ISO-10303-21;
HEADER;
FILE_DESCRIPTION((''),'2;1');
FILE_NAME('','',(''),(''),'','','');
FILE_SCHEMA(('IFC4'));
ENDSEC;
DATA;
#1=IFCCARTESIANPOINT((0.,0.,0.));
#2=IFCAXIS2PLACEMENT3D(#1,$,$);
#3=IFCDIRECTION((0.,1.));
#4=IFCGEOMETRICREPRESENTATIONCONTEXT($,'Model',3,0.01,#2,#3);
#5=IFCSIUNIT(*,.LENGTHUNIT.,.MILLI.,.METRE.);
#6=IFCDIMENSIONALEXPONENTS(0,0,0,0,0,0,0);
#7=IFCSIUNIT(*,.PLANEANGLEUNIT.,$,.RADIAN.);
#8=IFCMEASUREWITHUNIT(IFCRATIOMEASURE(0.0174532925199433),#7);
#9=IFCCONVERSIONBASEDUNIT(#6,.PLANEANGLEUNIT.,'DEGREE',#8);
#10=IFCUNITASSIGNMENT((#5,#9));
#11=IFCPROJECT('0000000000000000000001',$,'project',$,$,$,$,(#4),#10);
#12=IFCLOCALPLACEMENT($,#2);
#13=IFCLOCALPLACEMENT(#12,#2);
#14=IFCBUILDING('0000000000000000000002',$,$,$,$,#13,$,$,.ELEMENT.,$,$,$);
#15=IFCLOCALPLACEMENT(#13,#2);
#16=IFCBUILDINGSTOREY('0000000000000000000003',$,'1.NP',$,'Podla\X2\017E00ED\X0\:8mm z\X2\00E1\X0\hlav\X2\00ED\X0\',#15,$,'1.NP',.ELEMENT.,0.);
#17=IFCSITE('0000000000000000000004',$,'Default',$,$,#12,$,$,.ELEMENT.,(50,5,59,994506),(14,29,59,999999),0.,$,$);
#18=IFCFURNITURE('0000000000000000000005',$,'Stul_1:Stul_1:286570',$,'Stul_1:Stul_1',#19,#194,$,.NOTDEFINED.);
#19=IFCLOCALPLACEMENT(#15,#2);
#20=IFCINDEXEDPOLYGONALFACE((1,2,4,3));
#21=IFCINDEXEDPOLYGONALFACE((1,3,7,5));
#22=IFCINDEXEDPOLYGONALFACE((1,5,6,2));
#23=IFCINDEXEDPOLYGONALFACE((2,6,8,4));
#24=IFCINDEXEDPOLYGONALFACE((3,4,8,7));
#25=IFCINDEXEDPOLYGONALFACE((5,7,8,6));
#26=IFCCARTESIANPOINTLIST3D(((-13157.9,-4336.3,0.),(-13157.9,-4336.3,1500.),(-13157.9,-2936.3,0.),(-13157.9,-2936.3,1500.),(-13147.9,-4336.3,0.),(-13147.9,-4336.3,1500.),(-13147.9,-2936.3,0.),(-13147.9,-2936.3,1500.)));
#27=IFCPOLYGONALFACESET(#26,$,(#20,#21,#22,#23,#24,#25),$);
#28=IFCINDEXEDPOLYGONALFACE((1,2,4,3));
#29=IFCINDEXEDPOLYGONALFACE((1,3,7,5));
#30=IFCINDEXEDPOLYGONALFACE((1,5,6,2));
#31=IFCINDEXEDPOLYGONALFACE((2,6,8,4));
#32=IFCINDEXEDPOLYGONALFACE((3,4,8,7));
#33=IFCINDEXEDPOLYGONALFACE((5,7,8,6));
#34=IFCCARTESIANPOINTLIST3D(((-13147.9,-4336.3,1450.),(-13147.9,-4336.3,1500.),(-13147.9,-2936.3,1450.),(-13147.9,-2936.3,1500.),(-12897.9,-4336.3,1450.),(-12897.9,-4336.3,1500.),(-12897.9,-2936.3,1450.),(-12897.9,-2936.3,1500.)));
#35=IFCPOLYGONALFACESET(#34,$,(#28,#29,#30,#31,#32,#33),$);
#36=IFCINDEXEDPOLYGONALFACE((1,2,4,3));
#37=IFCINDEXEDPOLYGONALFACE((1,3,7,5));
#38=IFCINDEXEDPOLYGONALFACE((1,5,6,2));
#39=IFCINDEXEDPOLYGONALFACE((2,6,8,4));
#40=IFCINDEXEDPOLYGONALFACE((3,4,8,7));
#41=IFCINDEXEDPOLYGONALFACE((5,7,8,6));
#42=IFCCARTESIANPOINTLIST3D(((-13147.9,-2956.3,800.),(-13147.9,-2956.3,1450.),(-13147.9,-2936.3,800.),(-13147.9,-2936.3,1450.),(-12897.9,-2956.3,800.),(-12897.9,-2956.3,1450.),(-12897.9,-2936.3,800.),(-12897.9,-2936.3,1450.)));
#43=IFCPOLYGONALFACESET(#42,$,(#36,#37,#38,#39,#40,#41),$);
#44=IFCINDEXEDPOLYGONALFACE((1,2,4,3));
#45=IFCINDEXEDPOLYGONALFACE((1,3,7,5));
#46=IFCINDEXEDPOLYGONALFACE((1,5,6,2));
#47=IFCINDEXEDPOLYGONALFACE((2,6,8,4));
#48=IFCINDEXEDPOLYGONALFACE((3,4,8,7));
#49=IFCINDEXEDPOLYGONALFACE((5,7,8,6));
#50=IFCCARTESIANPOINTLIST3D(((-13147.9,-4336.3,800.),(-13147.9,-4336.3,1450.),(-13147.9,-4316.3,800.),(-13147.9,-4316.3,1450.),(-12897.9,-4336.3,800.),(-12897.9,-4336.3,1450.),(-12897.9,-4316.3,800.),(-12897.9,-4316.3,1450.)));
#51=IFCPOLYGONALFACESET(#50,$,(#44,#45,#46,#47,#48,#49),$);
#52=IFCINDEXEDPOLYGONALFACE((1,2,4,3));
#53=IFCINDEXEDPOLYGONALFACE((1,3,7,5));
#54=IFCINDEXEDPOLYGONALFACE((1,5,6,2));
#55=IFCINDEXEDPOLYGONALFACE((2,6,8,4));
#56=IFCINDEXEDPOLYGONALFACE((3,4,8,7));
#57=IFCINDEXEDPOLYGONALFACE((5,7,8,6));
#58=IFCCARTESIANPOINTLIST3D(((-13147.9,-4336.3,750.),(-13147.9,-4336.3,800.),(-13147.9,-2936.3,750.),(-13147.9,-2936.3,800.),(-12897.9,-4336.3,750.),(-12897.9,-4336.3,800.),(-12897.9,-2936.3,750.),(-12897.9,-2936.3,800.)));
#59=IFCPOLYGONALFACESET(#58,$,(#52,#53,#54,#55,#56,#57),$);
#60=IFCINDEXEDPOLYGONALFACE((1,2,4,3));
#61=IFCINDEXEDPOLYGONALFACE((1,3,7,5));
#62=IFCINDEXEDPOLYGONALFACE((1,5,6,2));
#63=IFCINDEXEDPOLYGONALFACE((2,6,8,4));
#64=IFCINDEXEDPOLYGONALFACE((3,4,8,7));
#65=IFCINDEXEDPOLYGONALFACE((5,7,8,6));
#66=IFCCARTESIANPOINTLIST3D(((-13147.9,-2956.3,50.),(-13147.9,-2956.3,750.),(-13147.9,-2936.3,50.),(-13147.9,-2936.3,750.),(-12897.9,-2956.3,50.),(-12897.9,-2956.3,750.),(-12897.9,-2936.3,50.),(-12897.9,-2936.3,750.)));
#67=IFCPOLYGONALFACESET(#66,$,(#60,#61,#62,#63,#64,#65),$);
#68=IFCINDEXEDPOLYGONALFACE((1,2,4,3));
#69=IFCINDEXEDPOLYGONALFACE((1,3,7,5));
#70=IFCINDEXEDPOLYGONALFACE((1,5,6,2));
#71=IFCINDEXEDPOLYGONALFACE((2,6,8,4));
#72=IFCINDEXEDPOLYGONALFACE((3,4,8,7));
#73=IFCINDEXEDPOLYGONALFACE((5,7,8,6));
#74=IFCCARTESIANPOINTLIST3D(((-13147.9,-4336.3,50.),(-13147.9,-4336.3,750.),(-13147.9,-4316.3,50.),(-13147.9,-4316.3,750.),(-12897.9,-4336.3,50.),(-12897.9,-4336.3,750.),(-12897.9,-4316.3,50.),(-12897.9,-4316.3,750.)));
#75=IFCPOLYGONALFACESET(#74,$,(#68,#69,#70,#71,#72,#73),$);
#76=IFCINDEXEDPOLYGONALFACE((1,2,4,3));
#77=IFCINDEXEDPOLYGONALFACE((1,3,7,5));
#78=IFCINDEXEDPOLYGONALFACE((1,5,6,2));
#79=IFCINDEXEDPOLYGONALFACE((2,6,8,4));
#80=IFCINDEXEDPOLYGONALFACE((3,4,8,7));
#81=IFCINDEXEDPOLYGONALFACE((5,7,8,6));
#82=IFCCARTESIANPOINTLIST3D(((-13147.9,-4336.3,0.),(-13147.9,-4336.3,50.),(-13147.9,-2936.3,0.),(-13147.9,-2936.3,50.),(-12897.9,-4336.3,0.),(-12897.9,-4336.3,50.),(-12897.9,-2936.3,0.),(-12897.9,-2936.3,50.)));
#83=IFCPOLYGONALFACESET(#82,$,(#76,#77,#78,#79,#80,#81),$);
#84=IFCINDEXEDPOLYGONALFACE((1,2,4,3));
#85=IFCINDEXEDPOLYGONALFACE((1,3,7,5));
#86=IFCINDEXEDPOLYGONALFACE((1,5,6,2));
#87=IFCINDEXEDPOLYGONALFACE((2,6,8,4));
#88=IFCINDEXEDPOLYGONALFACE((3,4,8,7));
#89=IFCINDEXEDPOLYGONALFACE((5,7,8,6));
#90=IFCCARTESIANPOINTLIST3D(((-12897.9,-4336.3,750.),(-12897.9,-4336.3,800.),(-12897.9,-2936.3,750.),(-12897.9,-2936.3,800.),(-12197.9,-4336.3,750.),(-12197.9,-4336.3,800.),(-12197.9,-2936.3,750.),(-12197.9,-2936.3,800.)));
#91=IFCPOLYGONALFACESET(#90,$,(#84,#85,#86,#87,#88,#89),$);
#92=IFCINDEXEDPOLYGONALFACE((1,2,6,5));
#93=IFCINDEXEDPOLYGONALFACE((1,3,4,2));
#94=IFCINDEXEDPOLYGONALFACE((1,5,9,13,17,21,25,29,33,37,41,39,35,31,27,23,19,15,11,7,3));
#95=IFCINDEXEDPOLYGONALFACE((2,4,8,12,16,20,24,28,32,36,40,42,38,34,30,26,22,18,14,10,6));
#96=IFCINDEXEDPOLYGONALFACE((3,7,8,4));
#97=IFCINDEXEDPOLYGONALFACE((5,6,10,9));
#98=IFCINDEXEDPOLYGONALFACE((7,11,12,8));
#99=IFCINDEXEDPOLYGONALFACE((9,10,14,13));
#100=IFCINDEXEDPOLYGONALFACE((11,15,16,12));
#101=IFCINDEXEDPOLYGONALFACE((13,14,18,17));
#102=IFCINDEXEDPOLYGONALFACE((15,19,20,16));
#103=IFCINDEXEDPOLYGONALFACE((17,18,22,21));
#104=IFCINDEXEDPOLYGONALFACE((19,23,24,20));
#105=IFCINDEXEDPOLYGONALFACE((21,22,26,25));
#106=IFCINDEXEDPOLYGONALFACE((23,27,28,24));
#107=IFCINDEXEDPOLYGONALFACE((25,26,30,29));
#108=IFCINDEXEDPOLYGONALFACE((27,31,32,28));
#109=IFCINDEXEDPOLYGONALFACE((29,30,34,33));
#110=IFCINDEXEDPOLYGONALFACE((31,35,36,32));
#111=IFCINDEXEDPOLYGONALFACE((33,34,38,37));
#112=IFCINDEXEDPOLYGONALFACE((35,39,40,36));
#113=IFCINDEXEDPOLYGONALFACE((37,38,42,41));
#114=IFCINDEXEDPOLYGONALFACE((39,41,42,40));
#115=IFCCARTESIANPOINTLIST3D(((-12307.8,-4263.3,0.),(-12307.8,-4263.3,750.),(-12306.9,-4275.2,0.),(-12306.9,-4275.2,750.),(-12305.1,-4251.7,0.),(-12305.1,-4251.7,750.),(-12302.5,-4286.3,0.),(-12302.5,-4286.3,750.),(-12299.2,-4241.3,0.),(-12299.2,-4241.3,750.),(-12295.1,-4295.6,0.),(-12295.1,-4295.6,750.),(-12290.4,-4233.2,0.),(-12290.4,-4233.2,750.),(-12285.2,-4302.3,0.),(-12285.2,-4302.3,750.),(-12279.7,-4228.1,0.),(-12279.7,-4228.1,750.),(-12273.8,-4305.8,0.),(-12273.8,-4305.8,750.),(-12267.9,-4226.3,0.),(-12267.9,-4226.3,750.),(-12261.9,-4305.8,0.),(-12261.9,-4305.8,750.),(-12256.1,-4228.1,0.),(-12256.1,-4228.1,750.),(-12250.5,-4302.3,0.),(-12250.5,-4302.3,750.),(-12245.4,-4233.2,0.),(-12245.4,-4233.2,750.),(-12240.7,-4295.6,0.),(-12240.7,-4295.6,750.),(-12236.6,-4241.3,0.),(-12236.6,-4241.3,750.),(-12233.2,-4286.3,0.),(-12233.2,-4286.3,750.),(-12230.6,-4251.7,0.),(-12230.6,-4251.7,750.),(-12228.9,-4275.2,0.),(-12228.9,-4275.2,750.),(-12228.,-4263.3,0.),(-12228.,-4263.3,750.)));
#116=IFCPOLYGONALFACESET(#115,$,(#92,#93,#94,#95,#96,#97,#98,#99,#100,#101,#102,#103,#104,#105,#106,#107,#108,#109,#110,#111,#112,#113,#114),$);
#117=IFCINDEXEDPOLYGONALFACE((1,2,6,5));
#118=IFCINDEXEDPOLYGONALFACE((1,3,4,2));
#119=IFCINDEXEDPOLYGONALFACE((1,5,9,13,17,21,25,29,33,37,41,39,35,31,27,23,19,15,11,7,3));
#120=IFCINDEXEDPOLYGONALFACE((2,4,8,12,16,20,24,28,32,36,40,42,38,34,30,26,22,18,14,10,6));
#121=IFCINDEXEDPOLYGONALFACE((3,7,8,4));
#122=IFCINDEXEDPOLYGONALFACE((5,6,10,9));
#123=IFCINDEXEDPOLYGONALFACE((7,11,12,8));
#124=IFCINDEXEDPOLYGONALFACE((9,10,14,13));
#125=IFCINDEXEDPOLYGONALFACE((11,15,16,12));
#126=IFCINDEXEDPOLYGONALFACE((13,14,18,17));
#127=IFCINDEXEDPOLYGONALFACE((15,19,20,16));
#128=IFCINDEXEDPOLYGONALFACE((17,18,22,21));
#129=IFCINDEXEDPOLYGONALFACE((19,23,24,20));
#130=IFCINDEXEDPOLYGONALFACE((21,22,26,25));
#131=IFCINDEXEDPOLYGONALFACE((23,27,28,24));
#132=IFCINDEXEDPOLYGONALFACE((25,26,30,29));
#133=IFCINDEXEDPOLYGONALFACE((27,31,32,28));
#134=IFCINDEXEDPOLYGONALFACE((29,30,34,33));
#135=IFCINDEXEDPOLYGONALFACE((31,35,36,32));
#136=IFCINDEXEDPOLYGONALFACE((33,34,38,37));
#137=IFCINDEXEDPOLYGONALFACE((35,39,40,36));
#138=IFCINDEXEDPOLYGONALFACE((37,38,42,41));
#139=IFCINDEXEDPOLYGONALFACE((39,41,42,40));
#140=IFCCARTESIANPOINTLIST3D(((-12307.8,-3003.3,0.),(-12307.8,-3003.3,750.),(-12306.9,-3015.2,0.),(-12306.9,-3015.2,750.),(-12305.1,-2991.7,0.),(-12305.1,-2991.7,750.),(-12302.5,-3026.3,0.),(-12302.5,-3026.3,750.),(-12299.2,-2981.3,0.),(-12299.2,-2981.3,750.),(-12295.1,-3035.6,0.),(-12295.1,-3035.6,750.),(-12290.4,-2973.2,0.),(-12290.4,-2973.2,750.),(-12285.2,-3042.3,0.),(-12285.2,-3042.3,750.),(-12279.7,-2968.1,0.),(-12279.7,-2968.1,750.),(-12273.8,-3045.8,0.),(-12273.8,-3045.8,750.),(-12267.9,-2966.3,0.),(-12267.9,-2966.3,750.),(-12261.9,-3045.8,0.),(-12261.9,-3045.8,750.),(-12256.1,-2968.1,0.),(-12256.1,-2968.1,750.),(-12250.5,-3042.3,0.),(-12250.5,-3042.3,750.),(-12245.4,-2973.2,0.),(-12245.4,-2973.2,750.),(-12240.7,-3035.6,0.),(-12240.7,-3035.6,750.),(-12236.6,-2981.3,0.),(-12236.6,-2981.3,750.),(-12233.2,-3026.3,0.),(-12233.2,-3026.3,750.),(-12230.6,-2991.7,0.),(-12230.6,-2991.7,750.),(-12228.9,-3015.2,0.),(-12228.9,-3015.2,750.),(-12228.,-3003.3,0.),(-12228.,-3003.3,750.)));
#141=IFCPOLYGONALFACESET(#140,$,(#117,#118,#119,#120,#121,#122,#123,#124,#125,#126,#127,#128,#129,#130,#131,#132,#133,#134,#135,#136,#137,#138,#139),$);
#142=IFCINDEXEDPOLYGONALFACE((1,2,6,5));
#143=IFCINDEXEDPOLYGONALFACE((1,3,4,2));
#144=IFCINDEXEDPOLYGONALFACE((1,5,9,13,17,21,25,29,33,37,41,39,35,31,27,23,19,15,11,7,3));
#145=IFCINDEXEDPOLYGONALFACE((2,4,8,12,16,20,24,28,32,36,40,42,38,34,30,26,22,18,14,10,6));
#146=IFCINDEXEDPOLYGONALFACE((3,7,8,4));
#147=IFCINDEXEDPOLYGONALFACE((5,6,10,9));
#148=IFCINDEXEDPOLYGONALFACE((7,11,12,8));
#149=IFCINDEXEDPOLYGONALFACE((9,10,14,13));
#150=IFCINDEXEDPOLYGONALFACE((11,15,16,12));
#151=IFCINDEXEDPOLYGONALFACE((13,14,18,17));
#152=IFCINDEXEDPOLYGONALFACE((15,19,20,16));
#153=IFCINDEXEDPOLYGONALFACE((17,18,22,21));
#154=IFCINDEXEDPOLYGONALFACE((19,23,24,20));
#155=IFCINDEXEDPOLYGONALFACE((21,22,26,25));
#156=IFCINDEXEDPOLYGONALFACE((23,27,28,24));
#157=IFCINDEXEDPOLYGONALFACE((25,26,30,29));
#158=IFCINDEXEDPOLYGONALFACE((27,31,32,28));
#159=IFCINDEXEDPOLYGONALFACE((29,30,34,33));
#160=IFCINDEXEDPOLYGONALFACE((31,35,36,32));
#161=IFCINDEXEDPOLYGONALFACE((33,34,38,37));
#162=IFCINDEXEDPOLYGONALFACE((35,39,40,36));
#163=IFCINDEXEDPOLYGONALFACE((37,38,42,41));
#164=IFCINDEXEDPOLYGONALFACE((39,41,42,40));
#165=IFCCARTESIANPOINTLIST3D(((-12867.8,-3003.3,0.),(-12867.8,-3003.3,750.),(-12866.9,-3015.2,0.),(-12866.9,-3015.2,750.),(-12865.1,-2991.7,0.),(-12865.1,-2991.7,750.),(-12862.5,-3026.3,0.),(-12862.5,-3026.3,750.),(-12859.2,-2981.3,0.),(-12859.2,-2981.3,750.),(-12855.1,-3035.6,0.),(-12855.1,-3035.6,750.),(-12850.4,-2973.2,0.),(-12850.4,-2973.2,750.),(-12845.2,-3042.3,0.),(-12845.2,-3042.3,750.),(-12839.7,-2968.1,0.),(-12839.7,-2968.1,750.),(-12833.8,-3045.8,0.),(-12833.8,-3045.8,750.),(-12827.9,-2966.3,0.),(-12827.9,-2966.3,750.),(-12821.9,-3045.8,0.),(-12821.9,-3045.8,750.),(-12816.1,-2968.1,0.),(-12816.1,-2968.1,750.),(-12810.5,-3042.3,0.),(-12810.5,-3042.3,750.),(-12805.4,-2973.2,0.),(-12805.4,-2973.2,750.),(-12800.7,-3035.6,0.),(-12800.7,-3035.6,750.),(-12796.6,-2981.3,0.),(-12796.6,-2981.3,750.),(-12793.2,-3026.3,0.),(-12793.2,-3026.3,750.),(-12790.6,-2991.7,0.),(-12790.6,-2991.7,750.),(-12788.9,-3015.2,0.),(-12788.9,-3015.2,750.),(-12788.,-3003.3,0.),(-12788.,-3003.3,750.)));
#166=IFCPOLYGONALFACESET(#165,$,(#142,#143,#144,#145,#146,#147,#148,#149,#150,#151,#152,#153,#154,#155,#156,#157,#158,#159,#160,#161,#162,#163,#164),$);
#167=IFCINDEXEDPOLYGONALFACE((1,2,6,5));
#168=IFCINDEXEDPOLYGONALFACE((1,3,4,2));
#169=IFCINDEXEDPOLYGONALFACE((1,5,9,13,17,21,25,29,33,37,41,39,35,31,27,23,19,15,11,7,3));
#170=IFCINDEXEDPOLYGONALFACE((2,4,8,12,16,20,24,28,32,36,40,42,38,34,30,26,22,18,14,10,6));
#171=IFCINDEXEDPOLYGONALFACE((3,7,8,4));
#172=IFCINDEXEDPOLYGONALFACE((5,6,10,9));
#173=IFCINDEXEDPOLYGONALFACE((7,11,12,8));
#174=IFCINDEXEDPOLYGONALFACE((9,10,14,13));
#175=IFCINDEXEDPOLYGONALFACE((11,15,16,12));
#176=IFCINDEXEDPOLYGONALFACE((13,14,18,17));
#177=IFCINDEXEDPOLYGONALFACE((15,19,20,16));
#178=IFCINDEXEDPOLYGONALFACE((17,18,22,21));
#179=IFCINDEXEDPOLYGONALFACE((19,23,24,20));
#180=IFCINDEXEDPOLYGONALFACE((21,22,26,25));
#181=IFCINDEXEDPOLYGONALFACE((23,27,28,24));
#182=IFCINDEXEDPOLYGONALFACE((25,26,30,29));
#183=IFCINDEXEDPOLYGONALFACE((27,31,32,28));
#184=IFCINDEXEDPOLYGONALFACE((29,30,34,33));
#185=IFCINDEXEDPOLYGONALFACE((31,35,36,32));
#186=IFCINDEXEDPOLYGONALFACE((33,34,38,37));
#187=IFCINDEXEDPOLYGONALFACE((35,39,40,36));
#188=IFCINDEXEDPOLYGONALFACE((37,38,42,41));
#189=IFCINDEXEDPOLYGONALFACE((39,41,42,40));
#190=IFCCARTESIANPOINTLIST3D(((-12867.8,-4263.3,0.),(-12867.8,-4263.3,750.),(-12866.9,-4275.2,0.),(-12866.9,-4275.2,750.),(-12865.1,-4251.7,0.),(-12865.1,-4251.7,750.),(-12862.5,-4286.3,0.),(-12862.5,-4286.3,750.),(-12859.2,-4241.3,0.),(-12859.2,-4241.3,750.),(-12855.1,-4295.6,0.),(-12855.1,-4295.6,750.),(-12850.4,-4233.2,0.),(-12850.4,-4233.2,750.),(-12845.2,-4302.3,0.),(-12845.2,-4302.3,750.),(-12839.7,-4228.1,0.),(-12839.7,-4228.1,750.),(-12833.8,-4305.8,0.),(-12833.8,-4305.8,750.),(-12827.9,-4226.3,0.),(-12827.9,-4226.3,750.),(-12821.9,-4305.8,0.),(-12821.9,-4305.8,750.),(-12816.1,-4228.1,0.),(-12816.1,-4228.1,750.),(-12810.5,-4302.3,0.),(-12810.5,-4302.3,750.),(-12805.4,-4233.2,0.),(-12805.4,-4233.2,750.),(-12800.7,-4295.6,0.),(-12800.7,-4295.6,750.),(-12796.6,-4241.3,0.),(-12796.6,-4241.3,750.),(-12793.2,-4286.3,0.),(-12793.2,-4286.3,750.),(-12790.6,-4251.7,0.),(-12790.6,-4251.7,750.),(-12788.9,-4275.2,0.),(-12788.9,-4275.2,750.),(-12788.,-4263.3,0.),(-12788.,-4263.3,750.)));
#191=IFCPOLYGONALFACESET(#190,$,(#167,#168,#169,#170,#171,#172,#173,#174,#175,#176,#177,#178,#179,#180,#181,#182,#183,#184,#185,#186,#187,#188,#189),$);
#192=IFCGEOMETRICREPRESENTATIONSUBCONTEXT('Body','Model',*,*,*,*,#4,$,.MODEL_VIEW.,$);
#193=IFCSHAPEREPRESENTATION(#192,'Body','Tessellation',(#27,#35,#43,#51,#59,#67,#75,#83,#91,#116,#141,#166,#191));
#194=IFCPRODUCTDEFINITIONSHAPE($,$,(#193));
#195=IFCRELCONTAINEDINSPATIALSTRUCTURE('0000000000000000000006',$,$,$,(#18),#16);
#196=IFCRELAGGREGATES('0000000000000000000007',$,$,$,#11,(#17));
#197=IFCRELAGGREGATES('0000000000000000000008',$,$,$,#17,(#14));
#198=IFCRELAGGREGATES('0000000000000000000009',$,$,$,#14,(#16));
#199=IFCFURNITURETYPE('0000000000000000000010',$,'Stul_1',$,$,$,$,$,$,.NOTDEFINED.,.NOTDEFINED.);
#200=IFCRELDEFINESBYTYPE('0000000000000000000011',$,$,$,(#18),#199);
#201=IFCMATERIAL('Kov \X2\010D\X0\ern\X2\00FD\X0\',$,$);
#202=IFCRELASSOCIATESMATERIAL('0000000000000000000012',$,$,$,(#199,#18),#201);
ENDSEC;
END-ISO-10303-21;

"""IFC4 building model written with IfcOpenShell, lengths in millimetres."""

from ifc_helpers import new_model, entity, si_unit, converted_unit, direction, frame, frame_2d, origin, origin_2d_with_axis, place, context, subcontext, project, spatial, rectangle, circle, extrude, source, transform, mapped, material, type_object, type_shapes, element, save


model = new_model("IFC4")

# Units and contexts
model_context = context("Model", 3, precision=0.01, world=origin(), true_north=direction((0.0, 1.0)))
body_context = subcontext(model_context, "Body", "Model", "MODEL_VIEW")
ifc_project = project(units=[si_unit("LENGTHUNIT", "METRE", prefix="MILLI"), converted_unit("PLANEANGLEUNIT", "DEGREE", entity("IfcRatioMeasure", 0.0174532925199433), si_unit("PLANEANGLEUNIT", "RADIAN"), dimensions=[0, 0, 0, 0, 0, 0, 0])], contexts=[model_context])

# Site, building, storey
site_placement = place(None, origin())
site = spatial("IfcSite", under=ifc_project, at=site_placement, Name="Default", CompositionType="ELEMENT", RefLatitude=(50, 5, 59, 994506), RefLongitude=(14, 29, 59, 999999), RefElevation=0.0)
building_placement = place(site_placement, origin())
building = spatial("IfcBuilding", under=site, at=building_placement, CompositionType="ELEMENT")
storey_placement = place(building_placement, origin())
storey = spatial("IfcBuildingStorey", under=building, at=storey_placement, Name="1.NP", ObjectType="Podlaží:8mm záhlaví", LongName="1.NP", CompositionType="ELEMENT", Elevation=0.0)

# Furniture
ifc_material_1 = material(Name="Kov černý")
furniture_type = type_object("IfcFurnitureType", Name="Stul_1", AssemblyPlace="NOTDEFINED", PredefinedType="NOTDEFINED", material=ifc_material_1)
shared_shape_1 = source(origin(), body_context, "Body", "SweptSolid", [
    extrude(rectangle(XDim=1400.0, YDim=10.0, at=origin_2d_with_axis()), frame((0.0, 605.0, 0.0), z_axis=(0.0, 0.0, 1.0), x_axis=(-1.0, 0.0, 0.0)), (0.0, 0.0, 1.0), 1500.0),
    extrude(rectangle(XDim=1400.0, YDim=250.0, at=frame_2d((0.0, 0.0), x_axis=(1.0, 0.0))), frame((0.0, 475.0, 1450.0), z_axis=(0.0, 0.0, 1.0), x_axis=(-1.0, 0.0, 0.0)), (0.0, 0.0, 1.0), 50.0),
    extrude(rectangle(XDim=20.0, YDim=250.0, at=origin_2d_with_axis()), frame((690.0, 475.0, 800.0), z_axis=(0.0, 0.0, 1.0), x_axis=(-1.0, 0.0, 0.0)), (0.0, 0.0, 1.0), 650.0),
    extrude(rectangle(XDim=20.0, YDim=250.0, at=frame_2d((0.0, 0.0), x_axis=(1.0, 0.0))), frame((-690.0, 475.0, 800.0), z_axis=(0.0, 0.0, 1.0), x_axis=(-1.0, 0.0, 0.0)), (0.0, 0.0, 1.0), 650.0),
    extrude(rectangle(XDim=1400.0, YDim=250.0, at=origin_2d_with_axis()), frame((0.0, 475.0, 750.0), z_axis=(0.0, 0.0, 1.0), x_axis=(-1.0, 0.0, 0.0)), (0.0, 0.0, 1.0), 50.0),
    extrude(rectangle(XDim=20.0, YDim=250.0, at=origin_2d_with_axis()), frame((690.0, 475.0, 50.0), z_axis=(0.0, 0.0, 1.0), x_axis=(-1.0, 0.0, 0.0)), (0.0, 0.0, 1.0), 700.0),
    extrude(rectangle(XDim=20.0, YDim=250.0, at=frame_2d((0.0, 0.0), x_axis=(1.0, 0.0))), frame((-690.0, 475.0, 50.0), z_axis=(0.0, 0.0, 1.0), x_axis=(-1.0, 0.0, 0.0)), (0.0, 0.0, 1.0), 700.0),
    extrude(rectangle(XDim=1400.0, YDim=250.0, at=origin_2d_with_axis()), frame((0.0, 475.0, 0.0), z_axis=(0.0, 0.0, 1.0), x_axis=(-1.0, 0.0, 0.0)), (0.0, 0.0, 1.0), 50.0),
    extrude(rectangle(XDim=1400.0, YDim=700.0, at=origin_2d_with_axis()), frame((0.0, 0.0, 750.0), z_axis=(0.0, 0.0, 1.0), x_axis=(-1.0, 0.0, 0.0)), (0.0, 0.0, 1.0), 50.0),
    extrude(circle(Radius=40.0, at=frame_2d((0.0, 0.0), x_axis=(1.0, 0.0))), frame((-630.0, -280.0, 0.0)), (0.0, 0.0, 1.0), 750.0),
    extrude(circle(Radius=40.0, at=frame_2d((0.0, 0.0), x_axis=(1.0, 0.0))), frame((630.0, -280.0, 0.0)), (0.0, 0.0, 1.0), 750.0),
    extrude(circle(Radius=40.0, at=frame_2d((0.0, 0.0), x_axis=(1.0, 0.0))), frame((630.0, 280.0, 0.0)), (0.0, 0.0, 1.0), 750.0),
    extrude(circle(Radius=40.0, at=frame_2d((0.0, 0.0), x_axis=(1.0, 0.0))), frame((-630.0, 280.0, 0.0)), (0.0, 0.0, 1.0), 750.0),
])
type_shapes(furniture_type, [shared_shape_1])
for number, where, z_axis, x_axis, name in (
    (1, (-12547.9, -3636.3, 0.0), (0.0, 0.0, 1.0), (0.0, 1.0, 0.0), "Stul_1:Stul_1:286570"),
):
    element("IfcFurniture", number, at=place(storey_placement, frame(where, z_axis=z_axis, x_axis=x_axis)), inside=storey, type_object=furniture_type, material=ifc_material_1, Name=name, ObjectType="Stul_1:Stul_1", PredefinedType="NOTDEFINED", context=body_context, shape_type="MappedRepresentation", body=[
        mapped(shared_shape_1, transform((0.0, 0.0, 0.0), scale=1.0)),
    ])

save(model, "model.ifc")
